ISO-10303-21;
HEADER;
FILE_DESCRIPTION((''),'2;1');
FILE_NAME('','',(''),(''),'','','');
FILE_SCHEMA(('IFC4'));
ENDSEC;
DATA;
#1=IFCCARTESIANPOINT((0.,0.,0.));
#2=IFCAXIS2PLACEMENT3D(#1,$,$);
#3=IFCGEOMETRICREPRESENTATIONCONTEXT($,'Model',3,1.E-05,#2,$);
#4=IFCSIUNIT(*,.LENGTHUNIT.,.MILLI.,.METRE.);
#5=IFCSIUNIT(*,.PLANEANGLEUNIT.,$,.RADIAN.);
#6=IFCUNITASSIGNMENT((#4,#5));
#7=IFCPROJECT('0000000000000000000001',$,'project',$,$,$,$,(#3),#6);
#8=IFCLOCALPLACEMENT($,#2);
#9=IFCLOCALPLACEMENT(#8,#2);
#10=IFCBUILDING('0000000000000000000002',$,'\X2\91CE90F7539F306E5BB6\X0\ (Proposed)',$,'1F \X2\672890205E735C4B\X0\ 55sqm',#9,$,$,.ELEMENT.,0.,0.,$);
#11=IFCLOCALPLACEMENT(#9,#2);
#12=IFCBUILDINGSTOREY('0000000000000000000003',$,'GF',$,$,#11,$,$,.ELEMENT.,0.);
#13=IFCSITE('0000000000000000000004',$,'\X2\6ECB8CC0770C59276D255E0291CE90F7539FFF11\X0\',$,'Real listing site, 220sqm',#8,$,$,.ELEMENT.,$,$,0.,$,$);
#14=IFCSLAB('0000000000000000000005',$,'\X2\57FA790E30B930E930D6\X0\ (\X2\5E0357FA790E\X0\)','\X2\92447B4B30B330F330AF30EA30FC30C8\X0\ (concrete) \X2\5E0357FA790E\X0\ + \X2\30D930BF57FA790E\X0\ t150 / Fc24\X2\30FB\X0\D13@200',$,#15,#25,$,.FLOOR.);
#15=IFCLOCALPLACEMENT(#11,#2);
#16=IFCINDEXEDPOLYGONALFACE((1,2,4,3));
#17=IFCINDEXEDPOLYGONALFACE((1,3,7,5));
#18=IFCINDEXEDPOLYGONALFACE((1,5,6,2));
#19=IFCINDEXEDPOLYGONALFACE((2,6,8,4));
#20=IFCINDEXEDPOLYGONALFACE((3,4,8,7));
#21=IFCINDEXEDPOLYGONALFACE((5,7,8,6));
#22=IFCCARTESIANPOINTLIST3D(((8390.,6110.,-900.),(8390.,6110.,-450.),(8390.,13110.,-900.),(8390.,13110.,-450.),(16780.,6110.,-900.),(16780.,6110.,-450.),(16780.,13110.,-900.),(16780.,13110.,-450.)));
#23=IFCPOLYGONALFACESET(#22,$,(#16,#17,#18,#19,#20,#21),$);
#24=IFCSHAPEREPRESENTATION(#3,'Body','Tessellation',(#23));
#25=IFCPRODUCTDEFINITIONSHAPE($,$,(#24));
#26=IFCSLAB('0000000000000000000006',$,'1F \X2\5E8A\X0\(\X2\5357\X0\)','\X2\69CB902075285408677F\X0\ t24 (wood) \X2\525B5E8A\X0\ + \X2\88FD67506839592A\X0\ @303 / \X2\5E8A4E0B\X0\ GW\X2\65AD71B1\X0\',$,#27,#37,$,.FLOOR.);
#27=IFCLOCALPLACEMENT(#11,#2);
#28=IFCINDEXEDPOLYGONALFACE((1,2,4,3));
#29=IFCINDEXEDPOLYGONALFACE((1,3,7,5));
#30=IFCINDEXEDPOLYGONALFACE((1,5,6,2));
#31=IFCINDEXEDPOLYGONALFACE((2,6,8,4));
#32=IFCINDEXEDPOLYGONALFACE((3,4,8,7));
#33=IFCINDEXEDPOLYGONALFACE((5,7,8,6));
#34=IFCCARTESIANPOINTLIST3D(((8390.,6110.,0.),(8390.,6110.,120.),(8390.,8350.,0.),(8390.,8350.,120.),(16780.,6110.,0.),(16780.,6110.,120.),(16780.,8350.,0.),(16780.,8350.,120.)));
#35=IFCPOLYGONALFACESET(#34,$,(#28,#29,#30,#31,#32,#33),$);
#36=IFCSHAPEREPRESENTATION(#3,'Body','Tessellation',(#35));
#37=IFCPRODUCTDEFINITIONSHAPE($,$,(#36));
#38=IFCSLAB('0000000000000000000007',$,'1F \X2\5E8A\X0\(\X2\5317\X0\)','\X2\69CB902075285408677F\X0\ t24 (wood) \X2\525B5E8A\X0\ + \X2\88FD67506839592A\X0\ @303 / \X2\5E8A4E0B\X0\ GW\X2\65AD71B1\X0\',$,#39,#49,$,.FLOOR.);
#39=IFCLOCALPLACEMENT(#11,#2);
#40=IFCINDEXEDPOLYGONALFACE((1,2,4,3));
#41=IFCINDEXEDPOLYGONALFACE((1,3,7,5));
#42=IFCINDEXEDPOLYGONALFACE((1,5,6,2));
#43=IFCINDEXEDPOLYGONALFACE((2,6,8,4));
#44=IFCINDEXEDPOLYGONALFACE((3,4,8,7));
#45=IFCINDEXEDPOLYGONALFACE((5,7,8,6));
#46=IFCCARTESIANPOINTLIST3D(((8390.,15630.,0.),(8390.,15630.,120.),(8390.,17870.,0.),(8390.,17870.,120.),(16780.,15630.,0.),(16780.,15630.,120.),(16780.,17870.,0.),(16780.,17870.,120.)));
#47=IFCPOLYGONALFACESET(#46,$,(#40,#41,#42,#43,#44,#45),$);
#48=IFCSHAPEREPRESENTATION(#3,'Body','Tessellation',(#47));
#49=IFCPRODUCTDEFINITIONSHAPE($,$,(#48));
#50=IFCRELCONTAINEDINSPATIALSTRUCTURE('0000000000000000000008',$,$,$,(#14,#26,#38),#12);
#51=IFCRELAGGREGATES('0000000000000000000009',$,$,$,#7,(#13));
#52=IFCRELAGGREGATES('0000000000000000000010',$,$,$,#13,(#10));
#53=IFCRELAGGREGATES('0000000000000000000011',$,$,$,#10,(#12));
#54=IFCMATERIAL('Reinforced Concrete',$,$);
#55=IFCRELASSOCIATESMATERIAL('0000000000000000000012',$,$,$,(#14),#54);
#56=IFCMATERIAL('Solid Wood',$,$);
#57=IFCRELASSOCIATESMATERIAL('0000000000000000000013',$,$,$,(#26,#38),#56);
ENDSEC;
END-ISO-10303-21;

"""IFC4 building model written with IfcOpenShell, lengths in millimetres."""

from ifc_helpers import new_model, si_unit, frame, frame_2d, origin, place, context, project, spatial, rectangle, extrude, material, element, save


model = new_model("IFC4")

# Units and contexts
model_context = context("Model", 3, precision=1e-05, world=origin())
ifc_project = project(units=[si_unit("LENGTHUNIT", "METRE", prefix="MILLI"), si_unit("PLANEANGLEUNIT", "RADIAN")], contexts=[model_context])

# Site, building, storey
site_placement = place(None, origin())
site = spatial("IfcSite", under=ifc_project, at=site_placement, Name="滋賀県大津市野郷原１", ObjectType="Real listing site, 220sqm", CompositionType="ELEMENT", RefElevation=0.0)
building_placement = place(site_placement, origin())
building = spatial("IfcBuilding", under=site, at=building_placement, Name="野郷原の家 (Proposed)", ObjectType="1F 木造平屋 55sqm", CompositionType="ELEMENT", ElevationOfRefHeight=0.0, ElevationOfTerrain=0.0)
storey_placement = place(building_placement, origin())
storey = spatial("IfcBuildingStorey", under=building, at=storey_placement, Name="GF", CompositionType="ELEMENT", Elevation=0.0)

# Slabs
ifc_material_1 = material(Name="Reinforced Concrete")
slab_1_placement = place(storey_placement, frame((4195.0, 3055.0, -450.0)))
element("IfcSlab", 1, at=slab_1_placement, inside=storey, material=ifc_material_1, Name="基礎スラブ (布基礎)", Description="鉄筋コンクリート (concrete) 布基礎 + ベタ基礎 t150 / Fc24・D13@200", PredefinedType="FLOOR", context=model_context, shape_type="SweptSolid", body=[
    extrude(rectangle(XDim=8390.0, YDim=7000.0, at=frame_2d((4195.0, 3500.0))), frame((4195.0, 3055.0, -450.0)), (0.0, 0.0, 1.0), 450.0),
])
ifc_material_2 = material(Name="Solid Wood")
slab_2_placement = place(storey_placement, frame((4195.0, 3055.0, 0.0)))
element("IfcSlab", 2, at=slab_2_placement, inside=storey, material=ifc_material_2, Name="1F 床(南)", Description="構造用合板 t24 (wood) 剛床 + 製材根太 @303 / 床下 GW断熱", PredefinedType="FLOOR", context=model_context, shape_type="SweptSolid", body=[
    extrude(rectangle(XDim=8390.0, YDim=2240.0, at=frame_2d((4195.0, 1120.0))), frame((4195.0, 3055.0, 0.0)), (0.0, 0.0, 1.0), 120.0),
])
slab_3_placement = place(storey_placement, frame((4195.0, 7815.0, 0.0)))
element("IfcSlab", 3, at=slab_3_placement, inside=storey, material=ifc_material_2, Name="1F 床(北)", Description="構造用合板 t24 (wood) 剛床 + 製材根太 @303 / 床下 GW断熱", PredefinedType="FLOOR", context=model_context, shape_type="SweptSolid", body=[
    extrude(rectangle(XDim=8390.0, YDim=2240.0, at=frame_2d((4195.0, 1120.0))), frame((4195.0, 7815.0, 0.0)), (0.0, 0.0, 1.0), 120.0),
])

save(model, "model.ifc")
